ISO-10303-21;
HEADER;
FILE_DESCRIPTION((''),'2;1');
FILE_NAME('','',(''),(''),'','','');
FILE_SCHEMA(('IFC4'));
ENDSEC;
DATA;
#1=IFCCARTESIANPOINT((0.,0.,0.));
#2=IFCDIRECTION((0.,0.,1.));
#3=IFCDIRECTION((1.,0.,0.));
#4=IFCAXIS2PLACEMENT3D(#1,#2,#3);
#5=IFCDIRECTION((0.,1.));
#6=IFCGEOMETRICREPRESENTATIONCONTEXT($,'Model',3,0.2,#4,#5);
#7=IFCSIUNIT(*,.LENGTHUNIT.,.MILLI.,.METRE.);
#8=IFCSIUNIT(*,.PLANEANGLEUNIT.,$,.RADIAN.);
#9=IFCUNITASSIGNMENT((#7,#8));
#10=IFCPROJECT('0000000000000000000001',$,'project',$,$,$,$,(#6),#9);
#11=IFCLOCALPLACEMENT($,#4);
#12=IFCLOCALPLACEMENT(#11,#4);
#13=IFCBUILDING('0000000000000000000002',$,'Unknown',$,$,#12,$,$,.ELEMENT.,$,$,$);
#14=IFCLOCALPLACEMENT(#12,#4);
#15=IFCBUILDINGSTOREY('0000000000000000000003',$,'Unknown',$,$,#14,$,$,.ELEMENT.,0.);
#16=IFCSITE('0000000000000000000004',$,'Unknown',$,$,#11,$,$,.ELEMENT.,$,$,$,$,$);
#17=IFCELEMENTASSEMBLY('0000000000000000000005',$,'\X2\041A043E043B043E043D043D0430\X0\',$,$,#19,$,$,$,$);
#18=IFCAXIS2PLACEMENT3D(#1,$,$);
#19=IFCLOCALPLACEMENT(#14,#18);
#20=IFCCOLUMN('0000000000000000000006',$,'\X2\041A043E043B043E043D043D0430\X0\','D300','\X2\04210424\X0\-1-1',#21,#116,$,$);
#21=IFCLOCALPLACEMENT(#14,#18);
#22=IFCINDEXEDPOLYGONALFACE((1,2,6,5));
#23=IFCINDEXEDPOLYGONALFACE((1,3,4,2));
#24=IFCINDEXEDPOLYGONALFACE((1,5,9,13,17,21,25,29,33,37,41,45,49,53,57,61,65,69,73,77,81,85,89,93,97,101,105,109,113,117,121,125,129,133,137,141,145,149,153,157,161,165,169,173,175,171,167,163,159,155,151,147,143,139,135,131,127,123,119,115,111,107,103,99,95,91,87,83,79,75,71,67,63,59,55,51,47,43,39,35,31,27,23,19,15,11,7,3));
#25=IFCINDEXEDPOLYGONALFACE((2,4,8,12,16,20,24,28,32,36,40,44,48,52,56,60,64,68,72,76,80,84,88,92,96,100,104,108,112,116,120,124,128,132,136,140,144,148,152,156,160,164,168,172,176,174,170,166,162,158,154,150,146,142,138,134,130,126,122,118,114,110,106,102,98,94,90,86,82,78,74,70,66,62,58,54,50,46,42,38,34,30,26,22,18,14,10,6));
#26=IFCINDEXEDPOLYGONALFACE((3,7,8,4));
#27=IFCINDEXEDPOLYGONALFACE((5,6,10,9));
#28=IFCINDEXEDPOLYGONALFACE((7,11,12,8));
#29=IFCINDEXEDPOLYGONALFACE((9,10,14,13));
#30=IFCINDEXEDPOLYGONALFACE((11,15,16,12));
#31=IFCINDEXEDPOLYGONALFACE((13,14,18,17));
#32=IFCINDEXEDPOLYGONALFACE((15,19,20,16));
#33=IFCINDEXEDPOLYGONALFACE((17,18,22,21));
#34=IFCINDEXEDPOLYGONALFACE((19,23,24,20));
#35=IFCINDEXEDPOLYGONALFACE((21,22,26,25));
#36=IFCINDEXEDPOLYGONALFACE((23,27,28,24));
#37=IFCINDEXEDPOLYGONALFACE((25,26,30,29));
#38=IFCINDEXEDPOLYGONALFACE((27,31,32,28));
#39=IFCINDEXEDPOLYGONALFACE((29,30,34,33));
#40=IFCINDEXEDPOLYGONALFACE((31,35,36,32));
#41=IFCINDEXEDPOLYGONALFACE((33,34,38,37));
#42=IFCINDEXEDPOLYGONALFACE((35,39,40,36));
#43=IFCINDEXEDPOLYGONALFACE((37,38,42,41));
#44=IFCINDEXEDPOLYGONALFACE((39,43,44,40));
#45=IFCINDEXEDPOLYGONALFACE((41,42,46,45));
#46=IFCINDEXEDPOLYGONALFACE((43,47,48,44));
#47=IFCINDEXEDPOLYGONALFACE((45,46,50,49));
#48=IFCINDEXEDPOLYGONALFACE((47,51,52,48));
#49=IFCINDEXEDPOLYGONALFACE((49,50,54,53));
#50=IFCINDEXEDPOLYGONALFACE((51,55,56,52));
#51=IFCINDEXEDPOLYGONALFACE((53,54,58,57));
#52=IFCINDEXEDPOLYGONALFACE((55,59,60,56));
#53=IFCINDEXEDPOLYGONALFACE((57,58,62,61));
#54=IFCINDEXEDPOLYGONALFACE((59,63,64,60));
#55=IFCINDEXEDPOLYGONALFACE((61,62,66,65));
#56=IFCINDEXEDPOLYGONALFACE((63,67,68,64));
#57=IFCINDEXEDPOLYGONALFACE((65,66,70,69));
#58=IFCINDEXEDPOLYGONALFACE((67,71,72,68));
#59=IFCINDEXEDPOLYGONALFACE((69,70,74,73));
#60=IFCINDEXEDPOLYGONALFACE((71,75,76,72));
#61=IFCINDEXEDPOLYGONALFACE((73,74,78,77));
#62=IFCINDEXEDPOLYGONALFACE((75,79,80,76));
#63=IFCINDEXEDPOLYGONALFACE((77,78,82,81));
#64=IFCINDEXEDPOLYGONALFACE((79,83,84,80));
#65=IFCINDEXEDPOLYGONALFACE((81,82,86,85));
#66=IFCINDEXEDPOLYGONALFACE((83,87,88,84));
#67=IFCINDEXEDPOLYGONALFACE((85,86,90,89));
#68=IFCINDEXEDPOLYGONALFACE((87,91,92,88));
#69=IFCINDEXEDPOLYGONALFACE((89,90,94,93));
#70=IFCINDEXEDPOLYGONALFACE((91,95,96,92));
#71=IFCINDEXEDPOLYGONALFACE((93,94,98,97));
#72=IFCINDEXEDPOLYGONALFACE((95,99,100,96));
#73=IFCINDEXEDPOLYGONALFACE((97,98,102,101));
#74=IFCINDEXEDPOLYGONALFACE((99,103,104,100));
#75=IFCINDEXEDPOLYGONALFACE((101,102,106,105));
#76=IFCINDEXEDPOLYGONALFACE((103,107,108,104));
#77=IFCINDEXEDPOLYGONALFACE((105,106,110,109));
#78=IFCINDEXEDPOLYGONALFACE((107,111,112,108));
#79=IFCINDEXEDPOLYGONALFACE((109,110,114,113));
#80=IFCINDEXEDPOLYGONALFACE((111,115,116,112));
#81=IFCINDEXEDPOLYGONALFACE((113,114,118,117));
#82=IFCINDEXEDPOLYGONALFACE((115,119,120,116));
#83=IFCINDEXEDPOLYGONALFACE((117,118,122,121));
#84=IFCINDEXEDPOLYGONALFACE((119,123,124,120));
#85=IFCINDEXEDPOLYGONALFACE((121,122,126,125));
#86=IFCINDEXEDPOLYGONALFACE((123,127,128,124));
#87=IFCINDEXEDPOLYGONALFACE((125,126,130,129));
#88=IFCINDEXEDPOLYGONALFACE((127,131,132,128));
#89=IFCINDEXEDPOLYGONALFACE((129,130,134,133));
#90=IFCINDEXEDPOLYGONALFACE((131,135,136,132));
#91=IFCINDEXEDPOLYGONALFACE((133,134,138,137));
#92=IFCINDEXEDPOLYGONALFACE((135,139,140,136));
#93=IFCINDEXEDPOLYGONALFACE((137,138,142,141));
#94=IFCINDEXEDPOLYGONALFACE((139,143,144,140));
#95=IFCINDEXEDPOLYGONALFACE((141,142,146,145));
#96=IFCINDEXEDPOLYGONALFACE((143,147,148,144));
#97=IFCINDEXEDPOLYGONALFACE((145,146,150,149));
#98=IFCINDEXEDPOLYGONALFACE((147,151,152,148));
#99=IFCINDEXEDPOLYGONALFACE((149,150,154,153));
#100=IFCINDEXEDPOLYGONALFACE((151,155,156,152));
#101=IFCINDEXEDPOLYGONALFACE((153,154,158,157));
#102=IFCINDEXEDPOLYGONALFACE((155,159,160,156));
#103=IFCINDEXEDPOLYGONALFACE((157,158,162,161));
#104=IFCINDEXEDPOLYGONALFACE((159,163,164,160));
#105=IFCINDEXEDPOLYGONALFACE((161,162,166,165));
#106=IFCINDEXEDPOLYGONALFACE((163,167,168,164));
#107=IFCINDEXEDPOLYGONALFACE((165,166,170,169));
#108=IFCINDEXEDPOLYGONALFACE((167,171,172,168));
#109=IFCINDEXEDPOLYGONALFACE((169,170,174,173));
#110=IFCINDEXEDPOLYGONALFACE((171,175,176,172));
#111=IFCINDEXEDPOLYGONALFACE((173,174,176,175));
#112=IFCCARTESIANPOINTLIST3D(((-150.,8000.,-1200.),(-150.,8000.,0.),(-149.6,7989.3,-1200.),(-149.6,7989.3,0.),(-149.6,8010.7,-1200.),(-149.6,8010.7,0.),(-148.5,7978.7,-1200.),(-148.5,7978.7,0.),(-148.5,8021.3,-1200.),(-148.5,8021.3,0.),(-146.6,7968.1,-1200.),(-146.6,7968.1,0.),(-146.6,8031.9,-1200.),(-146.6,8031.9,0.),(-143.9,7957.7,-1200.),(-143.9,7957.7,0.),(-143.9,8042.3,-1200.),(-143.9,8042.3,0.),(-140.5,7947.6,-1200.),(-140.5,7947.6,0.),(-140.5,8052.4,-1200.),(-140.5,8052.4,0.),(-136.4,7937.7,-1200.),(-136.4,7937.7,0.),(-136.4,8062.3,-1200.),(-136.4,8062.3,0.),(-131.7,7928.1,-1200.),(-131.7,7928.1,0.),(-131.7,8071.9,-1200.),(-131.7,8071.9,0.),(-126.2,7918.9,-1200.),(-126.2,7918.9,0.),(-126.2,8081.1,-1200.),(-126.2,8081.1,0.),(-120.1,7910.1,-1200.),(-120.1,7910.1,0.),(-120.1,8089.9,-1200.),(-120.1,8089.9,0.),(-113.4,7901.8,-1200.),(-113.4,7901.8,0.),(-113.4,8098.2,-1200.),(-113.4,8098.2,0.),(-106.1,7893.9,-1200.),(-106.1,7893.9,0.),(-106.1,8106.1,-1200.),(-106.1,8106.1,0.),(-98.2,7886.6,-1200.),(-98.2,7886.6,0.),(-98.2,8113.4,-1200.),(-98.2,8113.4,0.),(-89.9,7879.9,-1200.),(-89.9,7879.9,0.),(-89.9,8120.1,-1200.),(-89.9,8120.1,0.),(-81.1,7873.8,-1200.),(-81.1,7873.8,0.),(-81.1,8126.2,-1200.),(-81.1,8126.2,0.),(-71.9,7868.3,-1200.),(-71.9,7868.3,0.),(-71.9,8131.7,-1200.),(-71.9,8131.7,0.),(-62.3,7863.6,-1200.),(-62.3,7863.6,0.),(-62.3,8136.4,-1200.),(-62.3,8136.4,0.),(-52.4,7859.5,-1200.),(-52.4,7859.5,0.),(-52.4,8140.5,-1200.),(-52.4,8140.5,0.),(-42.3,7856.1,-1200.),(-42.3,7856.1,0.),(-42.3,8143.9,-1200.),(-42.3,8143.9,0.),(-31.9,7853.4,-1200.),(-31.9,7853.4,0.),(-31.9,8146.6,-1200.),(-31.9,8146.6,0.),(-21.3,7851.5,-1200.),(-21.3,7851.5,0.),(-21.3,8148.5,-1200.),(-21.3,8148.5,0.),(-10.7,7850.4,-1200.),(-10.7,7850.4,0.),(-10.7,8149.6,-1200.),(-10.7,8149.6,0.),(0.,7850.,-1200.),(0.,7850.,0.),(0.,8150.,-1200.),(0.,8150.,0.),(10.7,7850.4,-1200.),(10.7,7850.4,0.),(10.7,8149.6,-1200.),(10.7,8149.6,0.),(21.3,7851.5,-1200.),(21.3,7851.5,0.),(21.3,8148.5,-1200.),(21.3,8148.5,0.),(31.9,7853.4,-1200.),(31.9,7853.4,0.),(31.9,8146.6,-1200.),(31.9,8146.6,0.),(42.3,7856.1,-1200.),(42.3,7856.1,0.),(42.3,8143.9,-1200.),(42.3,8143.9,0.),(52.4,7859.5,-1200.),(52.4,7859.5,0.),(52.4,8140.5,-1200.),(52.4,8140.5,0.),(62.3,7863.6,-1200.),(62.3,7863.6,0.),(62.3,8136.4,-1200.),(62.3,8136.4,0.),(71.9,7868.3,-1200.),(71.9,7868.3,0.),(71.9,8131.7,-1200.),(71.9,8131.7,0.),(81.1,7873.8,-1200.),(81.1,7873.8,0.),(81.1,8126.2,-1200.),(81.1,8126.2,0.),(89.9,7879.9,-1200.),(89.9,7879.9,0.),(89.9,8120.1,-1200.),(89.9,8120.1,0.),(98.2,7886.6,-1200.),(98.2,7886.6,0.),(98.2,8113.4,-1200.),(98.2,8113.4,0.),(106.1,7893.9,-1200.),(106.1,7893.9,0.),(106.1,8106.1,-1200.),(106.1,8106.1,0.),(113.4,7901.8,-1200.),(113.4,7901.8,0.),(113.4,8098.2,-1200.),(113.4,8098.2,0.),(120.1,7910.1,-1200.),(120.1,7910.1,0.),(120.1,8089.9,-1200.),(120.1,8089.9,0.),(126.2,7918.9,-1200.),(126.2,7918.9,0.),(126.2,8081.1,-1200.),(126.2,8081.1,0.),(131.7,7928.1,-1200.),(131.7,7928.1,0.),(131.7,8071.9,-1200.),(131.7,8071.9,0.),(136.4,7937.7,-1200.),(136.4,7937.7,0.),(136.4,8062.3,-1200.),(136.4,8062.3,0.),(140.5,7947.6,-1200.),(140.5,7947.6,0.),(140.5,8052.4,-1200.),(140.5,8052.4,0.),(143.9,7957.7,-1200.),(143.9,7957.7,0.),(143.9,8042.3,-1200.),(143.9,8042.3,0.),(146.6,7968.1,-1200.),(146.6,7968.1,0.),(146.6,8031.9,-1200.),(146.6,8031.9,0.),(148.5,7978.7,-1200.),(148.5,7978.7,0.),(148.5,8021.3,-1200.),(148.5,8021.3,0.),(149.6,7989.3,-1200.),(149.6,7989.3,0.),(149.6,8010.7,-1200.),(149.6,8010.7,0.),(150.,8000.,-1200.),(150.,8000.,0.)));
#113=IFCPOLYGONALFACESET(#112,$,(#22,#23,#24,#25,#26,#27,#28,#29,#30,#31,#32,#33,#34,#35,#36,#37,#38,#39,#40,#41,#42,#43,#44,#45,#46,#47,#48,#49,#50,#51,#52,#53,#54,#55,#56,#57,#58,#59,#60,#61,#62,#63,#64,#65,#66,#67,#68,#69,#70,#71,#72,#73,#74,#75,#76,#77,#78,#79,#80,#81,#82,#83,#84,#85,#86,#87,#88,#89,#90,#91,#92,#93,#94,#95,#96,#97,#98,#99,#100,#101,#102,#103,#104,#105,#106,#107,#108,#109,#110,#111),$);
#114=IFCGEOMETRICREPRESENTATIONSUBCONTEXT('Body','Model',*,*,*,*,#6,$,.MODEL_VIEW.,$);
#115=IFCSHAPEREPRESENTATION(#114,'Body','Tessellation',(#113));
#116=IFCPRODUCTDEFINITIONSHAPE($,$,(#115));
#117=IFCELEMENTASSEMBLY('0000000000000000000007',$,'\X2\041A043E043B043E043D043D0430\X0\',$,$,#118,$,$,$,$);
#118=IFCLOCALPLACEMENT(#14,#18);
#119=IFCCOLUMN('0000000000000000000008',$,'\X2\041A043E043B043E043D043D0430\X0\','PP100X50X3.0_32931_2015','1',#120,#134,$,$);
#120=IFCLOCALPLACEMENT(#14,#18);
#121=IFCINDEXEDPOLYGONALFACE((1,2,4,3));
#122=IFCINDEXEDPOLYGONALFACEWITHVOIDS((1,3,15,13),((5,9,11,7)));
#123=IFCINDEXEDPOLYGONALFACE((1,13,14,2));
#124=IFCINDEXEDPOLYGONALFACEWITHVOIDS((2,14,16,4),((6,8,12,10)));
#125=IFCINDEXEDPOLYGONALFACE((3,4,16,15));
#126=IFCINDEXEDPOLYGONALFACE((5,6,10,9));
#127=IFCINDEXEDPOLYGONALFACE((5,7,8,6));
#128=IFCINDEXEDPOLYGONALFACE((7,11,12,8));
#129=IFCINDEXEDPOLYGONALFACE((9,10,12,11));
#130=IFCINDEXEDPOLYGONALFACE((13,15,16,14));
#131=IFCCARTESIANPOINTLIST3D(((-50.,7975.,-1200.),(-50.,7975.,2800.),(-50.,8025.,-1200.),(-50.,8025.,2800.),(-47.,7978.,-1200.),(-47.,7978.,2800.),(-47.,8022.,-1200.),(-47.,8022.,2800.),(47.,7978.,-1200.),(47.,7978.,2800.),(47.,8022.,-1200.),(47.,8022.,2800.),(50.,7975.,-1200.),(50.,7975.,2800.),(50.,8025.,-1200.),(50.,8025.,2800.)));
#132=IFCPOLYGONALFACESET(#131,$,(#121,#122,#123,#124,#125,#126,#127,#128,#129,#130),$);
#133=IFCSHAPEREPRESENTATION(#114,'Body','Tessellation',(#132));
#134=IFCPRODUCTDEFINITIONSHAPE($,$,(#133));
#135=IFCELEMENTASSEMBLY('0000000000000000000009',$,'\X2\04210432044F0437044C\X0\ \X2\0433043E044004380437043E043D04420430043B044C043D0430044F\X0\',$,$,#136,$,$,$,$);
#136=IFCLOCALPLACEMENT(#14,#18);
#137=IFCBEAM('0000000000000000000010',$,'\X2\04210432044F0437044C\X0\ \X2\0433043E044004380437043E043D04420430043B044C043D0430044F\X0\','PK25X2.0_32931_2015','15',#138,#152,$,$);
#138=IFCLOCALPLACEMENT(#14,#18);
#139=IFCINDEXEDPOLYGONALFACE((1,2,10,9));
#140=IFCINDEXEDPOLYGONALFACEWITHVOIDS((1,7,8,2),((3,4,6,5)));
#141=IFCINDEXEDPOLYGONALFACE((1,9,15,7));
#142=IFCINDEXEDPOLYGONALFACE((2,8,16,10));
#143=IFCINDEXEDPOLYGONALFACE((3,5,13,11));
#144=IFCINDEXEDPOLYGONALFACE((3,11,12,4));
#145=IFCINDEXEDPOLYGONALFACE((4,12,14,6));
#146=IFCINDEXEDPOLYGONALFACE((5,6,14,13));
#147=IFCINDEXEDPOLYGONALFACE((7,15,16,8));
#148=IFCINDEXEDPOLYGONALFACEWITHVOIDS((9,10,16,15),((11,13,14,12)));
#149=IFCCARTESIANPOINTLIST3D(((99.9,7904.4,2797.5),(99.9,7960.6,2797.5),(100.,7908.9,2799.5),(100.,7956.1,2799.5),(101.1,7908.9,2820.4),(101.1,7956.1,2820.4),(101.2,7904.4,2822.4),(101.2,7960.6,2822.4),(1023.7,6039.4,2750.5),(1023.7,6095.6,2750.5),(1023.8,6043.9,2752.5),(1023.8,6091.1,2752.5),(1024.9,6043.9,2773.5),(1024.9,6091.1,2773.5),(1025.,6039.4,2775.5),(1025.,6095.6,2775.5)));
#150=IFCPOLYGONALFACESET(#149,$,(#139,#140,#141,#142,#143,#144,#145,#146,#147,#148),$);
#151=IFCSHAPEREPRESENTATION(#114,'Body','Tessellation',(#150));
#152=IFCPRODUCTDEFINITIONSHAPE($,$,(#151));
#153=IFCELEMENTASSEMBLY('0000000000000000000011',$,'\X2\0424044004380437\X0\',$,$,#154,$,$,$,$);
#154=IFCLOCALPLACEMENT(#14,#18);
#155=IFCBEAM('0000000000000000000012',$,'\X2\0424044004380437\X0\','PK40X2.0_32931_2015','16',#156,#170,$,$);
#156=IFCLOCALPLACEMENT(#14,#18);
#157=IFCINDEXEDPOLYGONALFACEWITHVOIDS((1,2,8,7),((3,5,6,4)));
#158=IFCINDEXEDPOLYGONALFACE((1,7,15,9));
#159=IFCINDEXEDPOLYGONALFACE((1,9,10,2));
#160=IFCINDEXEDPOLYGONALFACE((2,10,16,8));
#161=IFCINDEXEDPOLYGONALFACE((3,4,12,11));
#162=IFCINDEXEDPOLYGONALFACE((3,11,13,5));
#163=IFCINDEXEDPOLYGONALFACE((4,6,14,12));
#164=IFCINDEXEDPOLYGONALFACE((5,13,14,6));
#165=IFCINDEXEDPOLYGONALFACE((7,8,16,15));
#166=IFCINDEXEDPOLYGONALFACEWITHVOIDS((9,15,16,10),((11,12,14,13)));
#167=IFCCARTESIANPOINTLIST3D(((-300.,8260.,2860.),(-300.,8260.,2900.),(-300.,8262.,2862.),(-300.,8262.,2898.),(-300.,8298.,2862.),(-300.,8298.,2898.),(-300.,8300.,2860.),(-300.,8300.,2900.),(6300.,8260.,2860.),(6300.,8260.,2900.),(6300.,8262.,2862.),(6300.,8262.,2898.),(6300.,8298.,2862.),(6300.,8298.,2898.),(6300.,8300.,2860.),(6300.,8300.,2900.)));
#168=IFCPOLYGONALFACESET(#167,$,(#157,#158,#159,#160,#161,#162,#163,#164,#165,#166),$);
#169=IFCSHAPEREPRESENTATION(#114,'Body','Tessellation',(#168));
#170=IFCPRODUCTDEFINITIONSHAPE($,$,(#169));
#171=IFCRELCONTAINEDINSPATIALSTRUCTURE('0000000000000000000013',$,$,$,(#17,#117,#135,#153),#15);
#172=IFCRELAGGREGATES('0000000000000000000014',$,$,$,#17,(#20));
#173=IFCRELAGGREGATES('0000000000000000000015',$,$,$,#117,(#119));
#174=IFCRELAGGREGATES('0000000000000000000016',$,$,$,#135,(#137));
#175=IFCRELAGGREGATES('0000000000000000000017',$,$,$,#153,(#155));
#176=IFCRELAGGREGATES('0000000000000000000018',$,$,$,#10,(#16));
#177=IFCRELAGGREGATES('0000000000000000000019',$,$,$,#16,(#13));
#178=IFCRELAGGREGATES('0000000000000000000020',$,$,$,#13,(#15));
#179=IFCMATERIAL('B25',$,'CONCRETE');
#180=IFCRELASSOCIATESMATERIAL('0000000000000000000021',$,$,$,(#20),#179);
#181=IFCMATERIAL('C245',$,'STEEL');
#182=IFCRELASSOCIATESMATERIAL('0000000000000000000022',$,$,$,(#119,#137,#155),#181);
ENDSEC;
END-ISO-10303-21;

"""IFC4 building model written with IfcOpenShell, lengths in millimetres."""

from ifc_helpers import new_model, si_unit, direction, frame, origin_with_axes, place, context, subcontext, project, spatial, line, indexed_curve, outline, extrude, material, element, aggregate, save


model = new_model("IFC4")

# Units and contexts
model_context = context("Model", 3, precision=0.2, world=origin_with_axes(), true_north=direction((0.0, 1.0)))
body_context = subcontext(model_context, "Body", "Model", "MODEL_VIEW")
ifc_project = project(units=[si_unit("LENGTHUNIT", "METRE", prefix="MILLI"), si_unit("PLANEANGLEUNIT", "RADIAN")], contexts=[model_context])

# Site, building, storey
site_placement = place(None, origin_with_axes())
site = spatial("IfcSite", under=ifc_project, at=site_placement, Name="Unknown", CompositionType="ELEMENT")
building_placement = place(site_placement, origin_with_axes())
building = spatial("IfcBuilding", under=site, at=building_placement, Name="Unknown", CompositionType="ELEMENT")
storey_placement = place(building_placement, origin_with_axes())
storey = spatial("IfcBuildingStorey", under=building, at=storey_placement, Name="Unknown", CompositionType="ELEMENT", Elevation=0.0)

# Element assemblies, columns
assembly_1_placement = place(storey_placement, frame((0.0, 8000.0, -1200.0), z_axis=(-1.0, 0.0, 0.0), x_axis=(0.0, 0.0, 1.0)))
assembly_1 = element("IfcElementAssembly", 1, at=assembly_1_placement, inside=storey, Name="Колонна")
ifc_material_1 = material(Name="B25", Category="CONCRETE")
column_1_placement = place(assembly_1_placement, origin_with_axes())
column_1 = element("IfcColumn", 2, at=column_1_placement, material=ifc_material_1, Name="Колонна", Description="D300", ObjectType="СФ-1-1", context=body_context, shape_type="SolidModel", body=[
    extrude(outline(indexed_curve([(150.0, 0.0), (149.6, 10.7), (148.5, 21.3), (146.6, 31.9), (143.9, 42.3), (140.5, 52.4), (136.4, 62.3), (131.7, 71.9), (126.2, 81.1), (120.1, 89.9), (113.4, 98.2), (106.1, 106.1), (98.2, 113.4), (89.9, 120.1), (81.1, 126.2), (71.9, 131.7), (62.3, 136.4), (52.4, 140.5), (42.3, 143.9), (31.9, 146.6), (21.3, 148.5), (10.7, 149.6), (0.0, 150.0), (-10.7, 149.6), (-21.3, 148.5), (-31.9, 146.6), (-42.3, 143.9), (-52.4, 140.5), (-62.3, 136.4), (-71.9, 131.7), (-81.1, 126.2), (-89.9, 120.1), (-98.2, 113.4), (-106.1, 106.1), (-113.4, 98.2), (-120.1, 89.9), (-126.2, 81.1), (-131.7, 71.9), (-136.4, 62.3), (-140.5, 52.4), (-143.9, 42.3), (-146.6, 31.9), (-148.5, 21.3), (-149.6, 10.7), (-150.0, 0.0), (-149.6, -10.7), (-148.5, -21.3), (-146.6, -31.9), (-143.9, -42.3), (-140.5, -52.4), (-136.4, -62.3), (-131.7, -71.9), (-126.2, -81.1), (-120.1, -89.9), (-113.4, -98.2), (-106.1, -106.1), (-98.2, -113.4), (-89.9, -120.1), (-81.1, -126.2), (-71.9, -131.7), (-62.3, -136.4), (-52.4, -140.5), (-42.3, -143.9), (-31.9, -146.6), (-21.3, -148.5), (-10.7, -149.6), (0.0, -150.0), (10.7, -149.6), (21.3, -148.5), (31.9, -146.6), (42.3, -143.9), (52.4, -140.5), (62.3, -136.4), (71.9, -131.7), (81.1, -126.2), (89.9, -120.1), (98.2, -113.4), (106.1, -106.1), (113.4, -98.2), (120.1, -89.9), (126.2, -81.1), (131.7, -71.9), (136.4, -62.3), (140.5, -52.4), (143.9, -42.3), (146.6, -31.9), (148.5, -21.3), (149.6, -10.7)], segments=[line(1, 2, 3, 4, 5, 6, 7, 8, 9, 10, 11, 12, 13, 14, 15, 16, 17, 18, 19, 20, 21, 22, 23, 24, 25, 26, 27, 28, 29, 30, 31, 32, 33, 34, 35, 36, 37, 38, 39, 40, 41, 42, 43, 44, 45, 46, 47, 48, 49, 50, 51, 52, 53, 54, 55, 56, 57, 58, 59, 60, 61, 62, 63, 64, 65, 66, 67, 68, 69, 70, 71, 72, 73, 74, 75, 76, 77, 78, 79, 80, 81, 82, 83, 84, 85, 86, 87, 88, 1)])), frame((0.0, 0.0, 0.0), z_axis=(-1.0, 0.0, 0.0), x_axis=(0.0, 0.0, 1.0)), (0.0, 0.0, -1.0), 1200.0),
])
aggregate(assembly_1, [column_1])
assembly_2_placement = place(storey_placement, frame((0.0, 8000.0, -1200.0), z_axis=(0.0, -1.0, 0.0), x_axis=(0.0, 0.0, 1.0)))
assembly_2 = element("IfcElementAssembly", 3, at=assembly_2_placement, inside=storey, Name="Колонна")
ifc_material_2 = material(Name="C245", Category="STEEL")
column_2_placement = place(assembly_2_placement, origin_with_axes())
column_2 = element("IfcColumn", 4, at=column_2_placement, material=ifc_material_2, Name="Колонна", Description="PP100X50X3.0_32931_2015", ObjectType="1", context=body_context, shape_type="SolidModel", body=[
    extrude(outline(indexed_curve([(-25.0, -50.0), (25.0, -50.0), (25.0, 50.0), (-25.0, 50.0)], segments=[line(1, 2, 3, 4, 1)]), holes=[indexed_curve([(-22.0, -47.0), (-22.0, 47.0), (22.0, 47.0), (22.0, -47.0)], segments=[line(1, 2, 3, 4, 1)])]), frame((0.0, 0.0, 0.0), z_axis=(-1.0, 0.0, 0.0), x_axis=(0.0, 0.0, 1.0)), (0.0, 0.0, -1.0), 4000.0),
])
aggregate(assembly_2, [column_2])

# Element assembly, beam, voiding features
assembly_3_placement = place(storey_placement, frame((73.4, 7987.4, 2811.3), z_axis=(-0.894709, -0.444326, 0.045494), x_axis=(0.443753, -0.895865, -0.022564)))
assembly_3 = element("IfcElementAssembly", 5, at=assembly_3_placement, inside=storey, Name="Связь горизонтальная")
beam_1_placement = place(assembly_3_placement, origin_with_axes())
beam_1 = element("IfcBeam", 6, at=beam_1_placement, material=ifc_material_2, Name="Связь горизонтальная", Description="PK25X2.0_32931_2015", ObjectType="15", context=body_context, shape_type="SolidModel", body=[
    extrude(outline(indexed_curve([(-12.5, -12.5), (12.5, -12.5), (12.5, 12.5), (-12.5, 12.5)], segments=[line(1, 2, 3, 4, 1)]), holes=[indexed_curve([(-10.5, -10.5), (-10.5, 10.5), (10.5, 10.5), (10.5, -10.5)], segments=[line(1, 2, 3, 4, 1)])]), frame((0.0, 0.0, 0.0), z_axis=(-1.0, 0.0, 0.0), x_axis=(0.0, 0.0, 1.0)), (0.0, 0.0, -1.0), 2204.4),
])
voiding_feature_1_placement = place(beam_1_placement, frame((3193.8, 12.5, 493.2), z_axis=(0.444326, 0.0, -0.895865), x_axis=(-0.895865, 0.0, -0.444326)))
element("IfcVoidingFeature", 7, at=voiding_feature_1_placement, cuts=beam_1, Name="CUT_BEAM", ObjectType="(?)", PredefinedType="HOLE", context=body_context, shape_type="SolidModel", body=[
    extrude(outline(indexed_curve([(-25.0, -25.0), (25.0, -25.0), (25.0, 25.0), (-25.0, 25.0)], segments=[line(1, 2, 3, 4, 1)])), frame((0.0, 0.0, 0.0), z_axis=(-1.0, 0.0, 0.0), x_axis=(0.0, 0.0, 1.0)), (0.0, 0.0, -1.0), 2220.1),
])
voiding_feature_2_placement = place(beam_1_placement, frame((999.5, 12.5, 493.2), z_axis=(0.444326, 0.0, -0.895865), x_axis=(-0.895865, 0.0, -0.444326)))
element("IfcVoidingFeature", 8, at=voiding_feature_2_placement, cuts=beam_1, Name="CUT_BEAM", ObjectType="(?)", PredefinedType="HOLE", context=body_context, shape_type="SolidModel", body=[
    extrude(outline(indexed_curve([(-25.0, -25.0), (25.0, -25.0), (25.0, 25.0), (-25.0, 25.0)], segments=[line(1, 2, 3, 4, 1)])), frame((0.0, 0.0, 0.0), z_axis=(-1.0, 0.0, 0.0), x_axis=(0.0, 0.0, 1.0)), (0.0, 0.0, -1.0), 2220.1),
])
aggregate(assembly_3, [beam_1])

# Element assembly, beam
assembly_4_placement = place(storey_placement, frame((-300.0, 8280.0, 2880.0), z_axis=(0.0, -1.0, 0.0), x_axis=(1.0, 0.0, 0.0)))
assembly_4 = element("IfcElementAssembly", 9, at=assembly_4_placement, inside=storey, Name="Фриз")
beam_2_placement = place(assembly_4_placement, origin_with_axes())
beam_2 = element("IfcBeam", 10, at=beam_2_placement, material=ifc_material_2, Name="Фриз", Description="PK40X2.0_32931_2015", ObjectType="16", context=body_context, shape_type="SolidModel", body=[
    extrude(outline(indexed_curve([(-20.0, -20.0), (20.0, -20.0), (20.0, 20.0), (-20.0, 20.0)], segments=[line(1, 2, 3, 4, 1)]), holes=[indexed_curve([(-18.0, -18.0), (-18.0, 18.0), (18.0, 18.0), (18.0, -18.0)], segments=[line(1, 2, 3, 4, 1)])]), frame((0.0, 0.0, 0.0), z_axis=(-1.0, 0.0, 0.0), x_axis=(0.0, 0.0, 1.0)), (0.0, 0.0, -1.0), 6600.0),
])
aggregate(assembly_4, [beam_2])

save(model, "model.ifc")
